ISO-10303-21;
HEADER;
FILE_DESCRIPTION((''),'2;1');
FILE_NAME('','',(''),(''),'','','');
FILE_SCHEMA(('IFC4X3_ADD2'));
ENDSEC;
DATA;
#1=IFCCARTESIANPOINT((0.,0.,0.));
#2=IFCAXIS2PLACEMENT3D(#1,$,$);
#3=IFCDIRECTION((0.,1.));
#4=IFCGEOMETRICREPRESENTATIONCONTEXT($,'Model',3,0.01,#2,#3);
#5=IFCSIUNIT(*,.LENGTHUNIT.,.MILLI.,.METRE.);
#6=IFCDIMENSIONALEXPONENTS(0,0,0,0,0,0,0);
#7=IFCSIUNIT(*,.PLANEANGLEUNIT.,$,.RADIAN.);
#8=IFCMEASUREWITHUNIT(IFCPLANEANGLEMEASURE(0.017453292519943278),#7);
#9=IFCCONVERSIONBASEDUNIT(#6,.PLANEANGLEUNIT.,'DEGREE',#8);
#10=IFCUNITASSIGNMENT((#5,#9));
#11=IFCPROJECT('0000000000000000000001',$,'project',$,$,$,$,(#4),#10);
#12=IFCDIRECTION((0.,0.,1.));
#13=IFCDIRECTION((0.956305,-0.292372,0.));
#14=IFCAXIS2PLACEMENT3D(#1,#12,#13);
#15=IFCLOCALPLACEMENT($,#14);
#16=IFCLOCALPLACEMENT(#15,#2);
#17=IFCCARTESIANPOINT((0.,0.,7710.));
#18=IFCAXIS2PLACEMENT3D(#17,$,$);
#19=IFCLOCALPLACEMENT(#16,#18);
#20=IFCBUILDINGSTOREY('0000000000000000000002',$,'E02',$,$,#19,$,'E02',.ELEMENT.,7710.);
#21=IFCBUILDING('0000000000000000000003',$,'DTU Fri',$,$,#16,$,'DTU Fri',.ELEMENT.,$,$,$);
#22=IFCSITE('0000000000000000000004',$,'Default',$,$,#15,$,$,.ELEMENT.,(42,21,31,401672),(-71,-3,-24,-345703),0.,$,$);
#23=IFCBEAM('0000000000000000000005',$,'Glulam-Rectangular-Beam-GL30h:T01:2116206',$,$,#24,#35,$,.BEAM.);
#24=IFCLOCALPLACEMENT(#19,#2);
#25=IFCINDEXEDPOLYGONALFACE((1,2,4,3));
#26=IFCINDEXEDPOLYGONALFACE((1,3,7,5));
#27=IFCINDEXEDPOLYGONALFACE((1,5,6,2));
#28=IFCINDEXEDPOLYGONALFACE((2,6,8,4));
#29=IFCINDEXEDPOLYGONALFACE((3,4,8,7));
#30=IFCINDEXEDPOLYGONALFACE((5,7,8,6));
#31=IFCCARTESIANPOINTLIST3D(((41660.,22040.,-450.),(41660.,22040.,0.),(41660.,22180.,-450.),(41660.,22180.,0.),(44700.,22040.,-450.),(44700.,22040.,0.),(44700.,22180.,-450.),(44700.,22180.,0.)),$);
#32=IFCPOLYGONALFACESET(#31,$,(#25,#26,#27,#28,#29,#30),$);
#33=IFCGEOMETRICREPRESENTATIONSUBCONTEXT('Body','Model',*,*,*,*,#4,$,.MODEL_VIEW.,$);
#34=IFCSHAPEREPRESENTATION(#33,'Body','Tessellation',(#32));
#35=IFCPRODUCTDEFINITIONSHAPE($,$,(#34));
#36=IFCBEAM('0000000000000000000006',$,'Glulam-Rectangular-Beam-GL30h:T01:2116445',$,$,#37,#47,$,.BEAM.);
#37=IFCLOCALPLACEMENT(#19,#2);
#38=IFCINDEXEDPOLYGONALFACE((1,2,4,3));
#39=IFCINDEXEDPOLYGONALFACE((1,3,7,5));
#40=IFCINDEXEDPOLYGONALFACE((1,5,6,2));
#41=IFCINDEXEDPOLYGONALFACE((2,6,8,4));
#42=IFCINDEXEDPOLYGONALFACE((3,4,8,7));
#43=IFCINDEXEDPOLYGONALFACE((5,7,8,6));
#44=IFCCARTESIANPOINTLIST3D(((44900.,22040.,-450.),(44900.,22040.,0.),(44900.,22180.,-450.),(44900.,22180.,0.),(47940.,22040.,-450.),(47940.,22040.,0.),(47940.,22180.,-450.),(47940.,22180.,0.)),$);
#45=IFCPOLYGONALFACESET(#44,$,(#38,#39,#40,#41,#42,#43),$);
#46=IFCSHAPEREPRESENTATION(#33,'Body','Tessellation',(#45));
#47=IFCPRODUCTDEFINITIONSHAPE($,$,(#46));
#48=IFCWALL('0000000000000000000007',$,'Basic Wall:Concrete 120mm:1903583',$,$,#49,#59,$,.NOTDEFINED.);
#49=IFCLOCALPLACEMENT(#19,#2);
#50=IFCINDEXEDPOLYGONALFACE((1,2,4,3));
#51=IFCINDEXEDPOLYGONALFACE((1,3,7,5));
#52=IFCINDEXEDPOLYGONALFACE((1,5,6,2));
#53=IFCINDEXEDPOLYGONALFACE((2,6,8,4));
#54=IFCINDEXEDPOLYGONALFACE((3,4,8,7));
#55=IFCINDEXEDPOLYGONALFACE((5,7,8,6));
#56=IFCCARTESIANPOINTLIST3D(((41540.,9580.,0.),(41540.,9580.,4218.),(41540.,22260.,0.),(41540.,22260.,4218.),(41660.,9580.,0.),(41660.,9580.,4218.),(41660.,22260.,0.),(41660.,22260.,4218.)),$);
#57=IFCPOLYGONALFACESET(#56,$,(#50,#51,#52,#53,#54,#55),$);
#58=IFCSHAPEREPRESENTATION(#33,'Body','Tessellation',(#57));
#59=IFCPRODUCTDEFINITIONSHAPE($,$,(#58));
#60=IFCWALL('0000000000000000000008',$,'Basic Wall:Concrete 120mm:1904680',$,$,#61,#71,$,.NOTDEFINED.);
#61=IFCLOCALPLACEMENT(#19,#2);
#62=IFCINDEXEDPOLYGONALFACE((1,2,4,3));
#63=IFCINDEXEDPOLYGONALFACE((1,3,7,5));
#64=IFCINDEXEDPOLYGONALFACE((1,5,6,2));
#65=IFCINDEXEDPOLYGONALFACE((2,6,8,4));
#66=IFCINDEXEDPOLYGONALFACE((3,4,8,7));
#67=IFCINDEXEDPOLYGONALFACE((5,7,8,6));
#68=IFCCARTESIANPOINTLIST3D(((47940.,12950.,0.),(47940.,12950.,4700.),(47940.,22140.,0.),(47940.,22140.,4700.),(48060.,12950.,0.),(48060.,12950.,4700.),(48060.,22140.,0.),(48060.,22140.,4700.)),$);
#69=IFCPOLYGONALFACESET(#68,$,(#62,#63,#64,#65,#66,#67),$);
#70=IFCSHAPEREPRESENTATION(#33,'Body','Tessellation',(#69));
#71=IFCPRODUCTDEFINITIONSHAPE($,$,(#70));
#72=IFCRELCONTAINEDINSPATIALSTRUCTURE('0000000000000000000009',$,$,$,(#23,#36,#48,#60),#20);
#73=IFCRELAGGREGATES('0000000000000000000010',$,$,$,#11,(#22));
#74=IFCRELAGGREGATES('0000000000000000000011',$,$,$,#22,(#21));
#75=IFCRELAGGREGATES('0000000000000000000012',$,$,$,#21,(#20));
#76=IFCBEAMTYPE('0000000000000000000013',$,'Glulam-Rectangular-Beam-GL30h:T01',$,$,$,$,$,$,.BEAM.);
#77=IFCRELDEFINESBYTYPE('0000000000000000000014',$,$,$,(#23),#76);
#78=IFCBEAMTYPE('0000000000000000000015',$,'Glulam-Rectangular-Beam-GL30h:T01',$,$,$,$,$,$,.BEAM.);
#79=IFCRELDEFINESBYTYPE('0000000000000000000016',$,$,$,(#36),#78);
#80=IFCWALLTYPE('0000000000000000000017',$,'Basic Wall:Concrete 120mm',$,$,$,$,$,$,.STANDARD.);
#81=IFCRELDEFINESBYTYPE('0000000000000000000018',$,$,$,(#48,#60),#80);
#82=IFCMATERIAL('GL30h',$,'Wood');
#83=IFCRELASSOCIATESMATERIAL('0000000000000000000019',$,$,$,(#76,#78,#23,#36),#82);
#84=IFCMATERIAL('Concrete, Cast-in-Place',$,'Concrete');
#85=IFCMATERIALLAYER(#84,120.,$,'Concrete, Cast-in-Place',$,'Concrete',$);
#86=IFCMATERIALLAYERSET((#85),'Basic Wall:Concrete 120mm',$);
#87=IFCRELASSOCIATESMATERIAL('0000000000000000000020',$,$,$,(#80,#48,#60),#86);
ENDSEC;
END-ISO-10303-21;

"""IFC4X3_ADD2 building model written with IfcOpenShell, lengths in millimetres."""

from ifc_helpers import new_model, entity, si_unit, converted_unit, direction, frame, frame_2d, origin, origin_2d_with_axis, place, context, subcontext, project, spatial, rectangle, extrude, source, transform, mapped, material, layer, layer_set, material_profile, profile_set, profile_usage, type_object, type_shapes, element, save


model = new_model("IFC4X3_ADD2")

# Units and contexts
model_context = context("Model", 3, precision=0.01, world=origin(), true_north=direction((0.0, 1.0)))
body_context = subcontext(model_context, "Body", "Model", "MODEL_VIEW")
ifc_project = project(units=[si_unit("LENGTHUNIT", "METRE", prefix="MILLI"), converted_unit("PLANEANGLEUNIT", "DEGREE", entity("IfcPlaneAngleMeasure", 0.017453292519943278), si_unit("PLANEANGLEUNIT", "RADIAN"), dimensions=[0, 0, 0, 0, 0, 0, 0])], contexts=[model_context])

# Site, building, storey
site_placement = place(None, frame((0.0, 0.0, 0.0), z_axis=(0.0, 0.0, 1.0), x_axis=(0.956305, -0.292372, 0.0)))
site = spatial("IfcSite", under=ifc_project, at=site_placement, Name="Default", CompositionType="ELEMENT", RefLatitude=(42, 21, 31, 401672), RefLongitude=(-71, -3, -24, -345703), RefElevation=0.0)
building_placement = place(site_placement, origin())
building = spatial("IfcBuilding", under=site, at=building_placement, Name="DTU Fri", LongName="DTU Fri", CompositionType="ELEMENT")
storey_placement = place(building_placement, frame((0.0, 0.0, 7710.0)))
storey = spatial("IfcBuildingStorey", under=building, at=storey_placement, Name="E02", LongName="E02", CompositionType="ELEMENT", Elevation=7710.0)

# Shared definitions
ifc_material_1 = material(Name="GL30h", Category="Wood")

# Beams
ifc_material_profile_1 = material_profile(ifc_material_1, rectangle(XDim=450.0, YDim=140.0, at=origin_2d_with_axis()), Name="T01")
ifc_profile_set_1 = profile_set([ifc_material_profile_1], Name="T01")
ifc_profile_usage_1 = profile_usage(ifc_profile_set_1, cardinal=8)
beam_type_1 = type_object("IfcBeamType", Name="Glulam-Rectangular-Beam-GL30h:T01", PredefinedType="BEAM", material=ifc_profile_set_1)
shared_shape_1 = source(origin(), body_context, "Body", "SweptSolid", [
    extrude(rectangle(XDim=450.0, YDim=140.0, at=origin_2d_with_axis()), frame((-1540.0, 0.0, 0.0), z_axis=(1.0, 0.0, 0.0), x_axis=(0.0, 0.0, -1.0)), (0.0, 0.0, 1.0), 3040.0),
])
type_shapes(beam_type_1, [shared_shape_1])
beam_1_placement = place(storey_placement, frame((43200.0, 22110.0, -225.0)))
element("IfcBeam", 1, at=beam_1_placement, inside=storey, type_object=beam_type_1, material=ifc_profile_usage_1, Name="Glulam-Rectangular-Beam-GL30h:T01:2116206", PredefinedType="BEAM", context=body_context, shape_type="MappedRepresentation", body=[
    mapped(shared_shape_1, transform((0.0, 0.0, 0.0), scale=1.0)),
])
beam_type_2 = type_object("IfcBeamType", Name="Glulam-Rectangular-Beam-GL30h:T01", PredefinedType="BEAM", material=ifc_profile_set_1)
shared_shape_2 = source(origin(), body_context, "Body", "SweptSolid", [
    extrude(rectangle(XDim=450.0, YDim=140.0, at=origin_2d_with_axis()), frame((-1500.0, 0.0, 0.0), z_axis=(1.0, 0.0, 0.0), x_axis=(0.0, 0.0, -1.0)), (0.0, 0.0, 1.0), 3040.0),
])
type_shapes(beam_type_2, [shared_shape_2])
beam_2_placement = place(storey_placement, frame((46400.0, 22110.0, -225.0)))
element("IfcBeam", 2, at=beam_2_placement, inside=storey, type_object=beam_type_2, material=ifc_profile_usage_1, Name="Glulam-Rectangular-Beam-GL30h:T01:2116445", PredefinedType="BEAM", context=body_context, shape_type="MappedRepresentation", body=[
    mapped(shared_shape_2, transform((0.0, 0.0, 0.0), scale=1.0)),
])

# Walls
ifc_material_2 = material(Name="Concrete, Cast-in-Place", Category="Concrete")
ifc_layer = layer(ifc_material_2, 120.0, Name="Concrete, Cast-in-Place", Category="Concrete")
ifc_layer_set = layer_set([ifc_layer], Name="Basic Wall:Concrete 120mm")
wall_type = type_object("IfcWallType", Name="Basic Wall:Concrete 120mm", PredefinedType="STANDARD", material=ifc_layer_set)
wall_1_placement = place(storey_placement, frame((41600.0, 22260.0, 0.0), z_axis=(0.0, 0.0, 1.0), x_axis=(0.0, -1.0, 0.0)))
element("IfcWall", 3, at=wall_1_placement, inside=storey, type_object=wall_type, material=ifc_layer_set, Name="Basic Wall:Concrete 120mm:1903583", PredefinedType="NOTDEFINED", context=body_context, shape_type="SweptSolid", body=[
    extrude(rectangle(XDim=12680.0, YDim=120.0, at=frame_2d((6340.0, 0.0), x_axis=(-1.0, 0.0))), origin(), (0.0, 0.0, 1.0), 4218.0),
])
wall_2_placement = place(storey_placement, frame((48000.0, 22140.0, 0.0), z_axis=(0.0, 0.0, 1.0), x_axis=(0.0, -1.0, 0.0)))
element("IfcWall", 4, at=wall_2_placement, inside=storey, type_object=wall_type, material=ifc_layer_set, Name="Basic Wall:Concrete 120mm:1904680", PredefinedType="NOTDEFINED", context=body_context, shape_type="SweptSolid", body=[
    extrude(rectangle(XDim=9190.0, YDim=120.0, at=frame_2d((4595.0, 0.0), x_axis=(-1.0, 0.0))), origin(), (0.0, 0.0, 1.0), 4700.0),
])

save(model, "model.ifc")
